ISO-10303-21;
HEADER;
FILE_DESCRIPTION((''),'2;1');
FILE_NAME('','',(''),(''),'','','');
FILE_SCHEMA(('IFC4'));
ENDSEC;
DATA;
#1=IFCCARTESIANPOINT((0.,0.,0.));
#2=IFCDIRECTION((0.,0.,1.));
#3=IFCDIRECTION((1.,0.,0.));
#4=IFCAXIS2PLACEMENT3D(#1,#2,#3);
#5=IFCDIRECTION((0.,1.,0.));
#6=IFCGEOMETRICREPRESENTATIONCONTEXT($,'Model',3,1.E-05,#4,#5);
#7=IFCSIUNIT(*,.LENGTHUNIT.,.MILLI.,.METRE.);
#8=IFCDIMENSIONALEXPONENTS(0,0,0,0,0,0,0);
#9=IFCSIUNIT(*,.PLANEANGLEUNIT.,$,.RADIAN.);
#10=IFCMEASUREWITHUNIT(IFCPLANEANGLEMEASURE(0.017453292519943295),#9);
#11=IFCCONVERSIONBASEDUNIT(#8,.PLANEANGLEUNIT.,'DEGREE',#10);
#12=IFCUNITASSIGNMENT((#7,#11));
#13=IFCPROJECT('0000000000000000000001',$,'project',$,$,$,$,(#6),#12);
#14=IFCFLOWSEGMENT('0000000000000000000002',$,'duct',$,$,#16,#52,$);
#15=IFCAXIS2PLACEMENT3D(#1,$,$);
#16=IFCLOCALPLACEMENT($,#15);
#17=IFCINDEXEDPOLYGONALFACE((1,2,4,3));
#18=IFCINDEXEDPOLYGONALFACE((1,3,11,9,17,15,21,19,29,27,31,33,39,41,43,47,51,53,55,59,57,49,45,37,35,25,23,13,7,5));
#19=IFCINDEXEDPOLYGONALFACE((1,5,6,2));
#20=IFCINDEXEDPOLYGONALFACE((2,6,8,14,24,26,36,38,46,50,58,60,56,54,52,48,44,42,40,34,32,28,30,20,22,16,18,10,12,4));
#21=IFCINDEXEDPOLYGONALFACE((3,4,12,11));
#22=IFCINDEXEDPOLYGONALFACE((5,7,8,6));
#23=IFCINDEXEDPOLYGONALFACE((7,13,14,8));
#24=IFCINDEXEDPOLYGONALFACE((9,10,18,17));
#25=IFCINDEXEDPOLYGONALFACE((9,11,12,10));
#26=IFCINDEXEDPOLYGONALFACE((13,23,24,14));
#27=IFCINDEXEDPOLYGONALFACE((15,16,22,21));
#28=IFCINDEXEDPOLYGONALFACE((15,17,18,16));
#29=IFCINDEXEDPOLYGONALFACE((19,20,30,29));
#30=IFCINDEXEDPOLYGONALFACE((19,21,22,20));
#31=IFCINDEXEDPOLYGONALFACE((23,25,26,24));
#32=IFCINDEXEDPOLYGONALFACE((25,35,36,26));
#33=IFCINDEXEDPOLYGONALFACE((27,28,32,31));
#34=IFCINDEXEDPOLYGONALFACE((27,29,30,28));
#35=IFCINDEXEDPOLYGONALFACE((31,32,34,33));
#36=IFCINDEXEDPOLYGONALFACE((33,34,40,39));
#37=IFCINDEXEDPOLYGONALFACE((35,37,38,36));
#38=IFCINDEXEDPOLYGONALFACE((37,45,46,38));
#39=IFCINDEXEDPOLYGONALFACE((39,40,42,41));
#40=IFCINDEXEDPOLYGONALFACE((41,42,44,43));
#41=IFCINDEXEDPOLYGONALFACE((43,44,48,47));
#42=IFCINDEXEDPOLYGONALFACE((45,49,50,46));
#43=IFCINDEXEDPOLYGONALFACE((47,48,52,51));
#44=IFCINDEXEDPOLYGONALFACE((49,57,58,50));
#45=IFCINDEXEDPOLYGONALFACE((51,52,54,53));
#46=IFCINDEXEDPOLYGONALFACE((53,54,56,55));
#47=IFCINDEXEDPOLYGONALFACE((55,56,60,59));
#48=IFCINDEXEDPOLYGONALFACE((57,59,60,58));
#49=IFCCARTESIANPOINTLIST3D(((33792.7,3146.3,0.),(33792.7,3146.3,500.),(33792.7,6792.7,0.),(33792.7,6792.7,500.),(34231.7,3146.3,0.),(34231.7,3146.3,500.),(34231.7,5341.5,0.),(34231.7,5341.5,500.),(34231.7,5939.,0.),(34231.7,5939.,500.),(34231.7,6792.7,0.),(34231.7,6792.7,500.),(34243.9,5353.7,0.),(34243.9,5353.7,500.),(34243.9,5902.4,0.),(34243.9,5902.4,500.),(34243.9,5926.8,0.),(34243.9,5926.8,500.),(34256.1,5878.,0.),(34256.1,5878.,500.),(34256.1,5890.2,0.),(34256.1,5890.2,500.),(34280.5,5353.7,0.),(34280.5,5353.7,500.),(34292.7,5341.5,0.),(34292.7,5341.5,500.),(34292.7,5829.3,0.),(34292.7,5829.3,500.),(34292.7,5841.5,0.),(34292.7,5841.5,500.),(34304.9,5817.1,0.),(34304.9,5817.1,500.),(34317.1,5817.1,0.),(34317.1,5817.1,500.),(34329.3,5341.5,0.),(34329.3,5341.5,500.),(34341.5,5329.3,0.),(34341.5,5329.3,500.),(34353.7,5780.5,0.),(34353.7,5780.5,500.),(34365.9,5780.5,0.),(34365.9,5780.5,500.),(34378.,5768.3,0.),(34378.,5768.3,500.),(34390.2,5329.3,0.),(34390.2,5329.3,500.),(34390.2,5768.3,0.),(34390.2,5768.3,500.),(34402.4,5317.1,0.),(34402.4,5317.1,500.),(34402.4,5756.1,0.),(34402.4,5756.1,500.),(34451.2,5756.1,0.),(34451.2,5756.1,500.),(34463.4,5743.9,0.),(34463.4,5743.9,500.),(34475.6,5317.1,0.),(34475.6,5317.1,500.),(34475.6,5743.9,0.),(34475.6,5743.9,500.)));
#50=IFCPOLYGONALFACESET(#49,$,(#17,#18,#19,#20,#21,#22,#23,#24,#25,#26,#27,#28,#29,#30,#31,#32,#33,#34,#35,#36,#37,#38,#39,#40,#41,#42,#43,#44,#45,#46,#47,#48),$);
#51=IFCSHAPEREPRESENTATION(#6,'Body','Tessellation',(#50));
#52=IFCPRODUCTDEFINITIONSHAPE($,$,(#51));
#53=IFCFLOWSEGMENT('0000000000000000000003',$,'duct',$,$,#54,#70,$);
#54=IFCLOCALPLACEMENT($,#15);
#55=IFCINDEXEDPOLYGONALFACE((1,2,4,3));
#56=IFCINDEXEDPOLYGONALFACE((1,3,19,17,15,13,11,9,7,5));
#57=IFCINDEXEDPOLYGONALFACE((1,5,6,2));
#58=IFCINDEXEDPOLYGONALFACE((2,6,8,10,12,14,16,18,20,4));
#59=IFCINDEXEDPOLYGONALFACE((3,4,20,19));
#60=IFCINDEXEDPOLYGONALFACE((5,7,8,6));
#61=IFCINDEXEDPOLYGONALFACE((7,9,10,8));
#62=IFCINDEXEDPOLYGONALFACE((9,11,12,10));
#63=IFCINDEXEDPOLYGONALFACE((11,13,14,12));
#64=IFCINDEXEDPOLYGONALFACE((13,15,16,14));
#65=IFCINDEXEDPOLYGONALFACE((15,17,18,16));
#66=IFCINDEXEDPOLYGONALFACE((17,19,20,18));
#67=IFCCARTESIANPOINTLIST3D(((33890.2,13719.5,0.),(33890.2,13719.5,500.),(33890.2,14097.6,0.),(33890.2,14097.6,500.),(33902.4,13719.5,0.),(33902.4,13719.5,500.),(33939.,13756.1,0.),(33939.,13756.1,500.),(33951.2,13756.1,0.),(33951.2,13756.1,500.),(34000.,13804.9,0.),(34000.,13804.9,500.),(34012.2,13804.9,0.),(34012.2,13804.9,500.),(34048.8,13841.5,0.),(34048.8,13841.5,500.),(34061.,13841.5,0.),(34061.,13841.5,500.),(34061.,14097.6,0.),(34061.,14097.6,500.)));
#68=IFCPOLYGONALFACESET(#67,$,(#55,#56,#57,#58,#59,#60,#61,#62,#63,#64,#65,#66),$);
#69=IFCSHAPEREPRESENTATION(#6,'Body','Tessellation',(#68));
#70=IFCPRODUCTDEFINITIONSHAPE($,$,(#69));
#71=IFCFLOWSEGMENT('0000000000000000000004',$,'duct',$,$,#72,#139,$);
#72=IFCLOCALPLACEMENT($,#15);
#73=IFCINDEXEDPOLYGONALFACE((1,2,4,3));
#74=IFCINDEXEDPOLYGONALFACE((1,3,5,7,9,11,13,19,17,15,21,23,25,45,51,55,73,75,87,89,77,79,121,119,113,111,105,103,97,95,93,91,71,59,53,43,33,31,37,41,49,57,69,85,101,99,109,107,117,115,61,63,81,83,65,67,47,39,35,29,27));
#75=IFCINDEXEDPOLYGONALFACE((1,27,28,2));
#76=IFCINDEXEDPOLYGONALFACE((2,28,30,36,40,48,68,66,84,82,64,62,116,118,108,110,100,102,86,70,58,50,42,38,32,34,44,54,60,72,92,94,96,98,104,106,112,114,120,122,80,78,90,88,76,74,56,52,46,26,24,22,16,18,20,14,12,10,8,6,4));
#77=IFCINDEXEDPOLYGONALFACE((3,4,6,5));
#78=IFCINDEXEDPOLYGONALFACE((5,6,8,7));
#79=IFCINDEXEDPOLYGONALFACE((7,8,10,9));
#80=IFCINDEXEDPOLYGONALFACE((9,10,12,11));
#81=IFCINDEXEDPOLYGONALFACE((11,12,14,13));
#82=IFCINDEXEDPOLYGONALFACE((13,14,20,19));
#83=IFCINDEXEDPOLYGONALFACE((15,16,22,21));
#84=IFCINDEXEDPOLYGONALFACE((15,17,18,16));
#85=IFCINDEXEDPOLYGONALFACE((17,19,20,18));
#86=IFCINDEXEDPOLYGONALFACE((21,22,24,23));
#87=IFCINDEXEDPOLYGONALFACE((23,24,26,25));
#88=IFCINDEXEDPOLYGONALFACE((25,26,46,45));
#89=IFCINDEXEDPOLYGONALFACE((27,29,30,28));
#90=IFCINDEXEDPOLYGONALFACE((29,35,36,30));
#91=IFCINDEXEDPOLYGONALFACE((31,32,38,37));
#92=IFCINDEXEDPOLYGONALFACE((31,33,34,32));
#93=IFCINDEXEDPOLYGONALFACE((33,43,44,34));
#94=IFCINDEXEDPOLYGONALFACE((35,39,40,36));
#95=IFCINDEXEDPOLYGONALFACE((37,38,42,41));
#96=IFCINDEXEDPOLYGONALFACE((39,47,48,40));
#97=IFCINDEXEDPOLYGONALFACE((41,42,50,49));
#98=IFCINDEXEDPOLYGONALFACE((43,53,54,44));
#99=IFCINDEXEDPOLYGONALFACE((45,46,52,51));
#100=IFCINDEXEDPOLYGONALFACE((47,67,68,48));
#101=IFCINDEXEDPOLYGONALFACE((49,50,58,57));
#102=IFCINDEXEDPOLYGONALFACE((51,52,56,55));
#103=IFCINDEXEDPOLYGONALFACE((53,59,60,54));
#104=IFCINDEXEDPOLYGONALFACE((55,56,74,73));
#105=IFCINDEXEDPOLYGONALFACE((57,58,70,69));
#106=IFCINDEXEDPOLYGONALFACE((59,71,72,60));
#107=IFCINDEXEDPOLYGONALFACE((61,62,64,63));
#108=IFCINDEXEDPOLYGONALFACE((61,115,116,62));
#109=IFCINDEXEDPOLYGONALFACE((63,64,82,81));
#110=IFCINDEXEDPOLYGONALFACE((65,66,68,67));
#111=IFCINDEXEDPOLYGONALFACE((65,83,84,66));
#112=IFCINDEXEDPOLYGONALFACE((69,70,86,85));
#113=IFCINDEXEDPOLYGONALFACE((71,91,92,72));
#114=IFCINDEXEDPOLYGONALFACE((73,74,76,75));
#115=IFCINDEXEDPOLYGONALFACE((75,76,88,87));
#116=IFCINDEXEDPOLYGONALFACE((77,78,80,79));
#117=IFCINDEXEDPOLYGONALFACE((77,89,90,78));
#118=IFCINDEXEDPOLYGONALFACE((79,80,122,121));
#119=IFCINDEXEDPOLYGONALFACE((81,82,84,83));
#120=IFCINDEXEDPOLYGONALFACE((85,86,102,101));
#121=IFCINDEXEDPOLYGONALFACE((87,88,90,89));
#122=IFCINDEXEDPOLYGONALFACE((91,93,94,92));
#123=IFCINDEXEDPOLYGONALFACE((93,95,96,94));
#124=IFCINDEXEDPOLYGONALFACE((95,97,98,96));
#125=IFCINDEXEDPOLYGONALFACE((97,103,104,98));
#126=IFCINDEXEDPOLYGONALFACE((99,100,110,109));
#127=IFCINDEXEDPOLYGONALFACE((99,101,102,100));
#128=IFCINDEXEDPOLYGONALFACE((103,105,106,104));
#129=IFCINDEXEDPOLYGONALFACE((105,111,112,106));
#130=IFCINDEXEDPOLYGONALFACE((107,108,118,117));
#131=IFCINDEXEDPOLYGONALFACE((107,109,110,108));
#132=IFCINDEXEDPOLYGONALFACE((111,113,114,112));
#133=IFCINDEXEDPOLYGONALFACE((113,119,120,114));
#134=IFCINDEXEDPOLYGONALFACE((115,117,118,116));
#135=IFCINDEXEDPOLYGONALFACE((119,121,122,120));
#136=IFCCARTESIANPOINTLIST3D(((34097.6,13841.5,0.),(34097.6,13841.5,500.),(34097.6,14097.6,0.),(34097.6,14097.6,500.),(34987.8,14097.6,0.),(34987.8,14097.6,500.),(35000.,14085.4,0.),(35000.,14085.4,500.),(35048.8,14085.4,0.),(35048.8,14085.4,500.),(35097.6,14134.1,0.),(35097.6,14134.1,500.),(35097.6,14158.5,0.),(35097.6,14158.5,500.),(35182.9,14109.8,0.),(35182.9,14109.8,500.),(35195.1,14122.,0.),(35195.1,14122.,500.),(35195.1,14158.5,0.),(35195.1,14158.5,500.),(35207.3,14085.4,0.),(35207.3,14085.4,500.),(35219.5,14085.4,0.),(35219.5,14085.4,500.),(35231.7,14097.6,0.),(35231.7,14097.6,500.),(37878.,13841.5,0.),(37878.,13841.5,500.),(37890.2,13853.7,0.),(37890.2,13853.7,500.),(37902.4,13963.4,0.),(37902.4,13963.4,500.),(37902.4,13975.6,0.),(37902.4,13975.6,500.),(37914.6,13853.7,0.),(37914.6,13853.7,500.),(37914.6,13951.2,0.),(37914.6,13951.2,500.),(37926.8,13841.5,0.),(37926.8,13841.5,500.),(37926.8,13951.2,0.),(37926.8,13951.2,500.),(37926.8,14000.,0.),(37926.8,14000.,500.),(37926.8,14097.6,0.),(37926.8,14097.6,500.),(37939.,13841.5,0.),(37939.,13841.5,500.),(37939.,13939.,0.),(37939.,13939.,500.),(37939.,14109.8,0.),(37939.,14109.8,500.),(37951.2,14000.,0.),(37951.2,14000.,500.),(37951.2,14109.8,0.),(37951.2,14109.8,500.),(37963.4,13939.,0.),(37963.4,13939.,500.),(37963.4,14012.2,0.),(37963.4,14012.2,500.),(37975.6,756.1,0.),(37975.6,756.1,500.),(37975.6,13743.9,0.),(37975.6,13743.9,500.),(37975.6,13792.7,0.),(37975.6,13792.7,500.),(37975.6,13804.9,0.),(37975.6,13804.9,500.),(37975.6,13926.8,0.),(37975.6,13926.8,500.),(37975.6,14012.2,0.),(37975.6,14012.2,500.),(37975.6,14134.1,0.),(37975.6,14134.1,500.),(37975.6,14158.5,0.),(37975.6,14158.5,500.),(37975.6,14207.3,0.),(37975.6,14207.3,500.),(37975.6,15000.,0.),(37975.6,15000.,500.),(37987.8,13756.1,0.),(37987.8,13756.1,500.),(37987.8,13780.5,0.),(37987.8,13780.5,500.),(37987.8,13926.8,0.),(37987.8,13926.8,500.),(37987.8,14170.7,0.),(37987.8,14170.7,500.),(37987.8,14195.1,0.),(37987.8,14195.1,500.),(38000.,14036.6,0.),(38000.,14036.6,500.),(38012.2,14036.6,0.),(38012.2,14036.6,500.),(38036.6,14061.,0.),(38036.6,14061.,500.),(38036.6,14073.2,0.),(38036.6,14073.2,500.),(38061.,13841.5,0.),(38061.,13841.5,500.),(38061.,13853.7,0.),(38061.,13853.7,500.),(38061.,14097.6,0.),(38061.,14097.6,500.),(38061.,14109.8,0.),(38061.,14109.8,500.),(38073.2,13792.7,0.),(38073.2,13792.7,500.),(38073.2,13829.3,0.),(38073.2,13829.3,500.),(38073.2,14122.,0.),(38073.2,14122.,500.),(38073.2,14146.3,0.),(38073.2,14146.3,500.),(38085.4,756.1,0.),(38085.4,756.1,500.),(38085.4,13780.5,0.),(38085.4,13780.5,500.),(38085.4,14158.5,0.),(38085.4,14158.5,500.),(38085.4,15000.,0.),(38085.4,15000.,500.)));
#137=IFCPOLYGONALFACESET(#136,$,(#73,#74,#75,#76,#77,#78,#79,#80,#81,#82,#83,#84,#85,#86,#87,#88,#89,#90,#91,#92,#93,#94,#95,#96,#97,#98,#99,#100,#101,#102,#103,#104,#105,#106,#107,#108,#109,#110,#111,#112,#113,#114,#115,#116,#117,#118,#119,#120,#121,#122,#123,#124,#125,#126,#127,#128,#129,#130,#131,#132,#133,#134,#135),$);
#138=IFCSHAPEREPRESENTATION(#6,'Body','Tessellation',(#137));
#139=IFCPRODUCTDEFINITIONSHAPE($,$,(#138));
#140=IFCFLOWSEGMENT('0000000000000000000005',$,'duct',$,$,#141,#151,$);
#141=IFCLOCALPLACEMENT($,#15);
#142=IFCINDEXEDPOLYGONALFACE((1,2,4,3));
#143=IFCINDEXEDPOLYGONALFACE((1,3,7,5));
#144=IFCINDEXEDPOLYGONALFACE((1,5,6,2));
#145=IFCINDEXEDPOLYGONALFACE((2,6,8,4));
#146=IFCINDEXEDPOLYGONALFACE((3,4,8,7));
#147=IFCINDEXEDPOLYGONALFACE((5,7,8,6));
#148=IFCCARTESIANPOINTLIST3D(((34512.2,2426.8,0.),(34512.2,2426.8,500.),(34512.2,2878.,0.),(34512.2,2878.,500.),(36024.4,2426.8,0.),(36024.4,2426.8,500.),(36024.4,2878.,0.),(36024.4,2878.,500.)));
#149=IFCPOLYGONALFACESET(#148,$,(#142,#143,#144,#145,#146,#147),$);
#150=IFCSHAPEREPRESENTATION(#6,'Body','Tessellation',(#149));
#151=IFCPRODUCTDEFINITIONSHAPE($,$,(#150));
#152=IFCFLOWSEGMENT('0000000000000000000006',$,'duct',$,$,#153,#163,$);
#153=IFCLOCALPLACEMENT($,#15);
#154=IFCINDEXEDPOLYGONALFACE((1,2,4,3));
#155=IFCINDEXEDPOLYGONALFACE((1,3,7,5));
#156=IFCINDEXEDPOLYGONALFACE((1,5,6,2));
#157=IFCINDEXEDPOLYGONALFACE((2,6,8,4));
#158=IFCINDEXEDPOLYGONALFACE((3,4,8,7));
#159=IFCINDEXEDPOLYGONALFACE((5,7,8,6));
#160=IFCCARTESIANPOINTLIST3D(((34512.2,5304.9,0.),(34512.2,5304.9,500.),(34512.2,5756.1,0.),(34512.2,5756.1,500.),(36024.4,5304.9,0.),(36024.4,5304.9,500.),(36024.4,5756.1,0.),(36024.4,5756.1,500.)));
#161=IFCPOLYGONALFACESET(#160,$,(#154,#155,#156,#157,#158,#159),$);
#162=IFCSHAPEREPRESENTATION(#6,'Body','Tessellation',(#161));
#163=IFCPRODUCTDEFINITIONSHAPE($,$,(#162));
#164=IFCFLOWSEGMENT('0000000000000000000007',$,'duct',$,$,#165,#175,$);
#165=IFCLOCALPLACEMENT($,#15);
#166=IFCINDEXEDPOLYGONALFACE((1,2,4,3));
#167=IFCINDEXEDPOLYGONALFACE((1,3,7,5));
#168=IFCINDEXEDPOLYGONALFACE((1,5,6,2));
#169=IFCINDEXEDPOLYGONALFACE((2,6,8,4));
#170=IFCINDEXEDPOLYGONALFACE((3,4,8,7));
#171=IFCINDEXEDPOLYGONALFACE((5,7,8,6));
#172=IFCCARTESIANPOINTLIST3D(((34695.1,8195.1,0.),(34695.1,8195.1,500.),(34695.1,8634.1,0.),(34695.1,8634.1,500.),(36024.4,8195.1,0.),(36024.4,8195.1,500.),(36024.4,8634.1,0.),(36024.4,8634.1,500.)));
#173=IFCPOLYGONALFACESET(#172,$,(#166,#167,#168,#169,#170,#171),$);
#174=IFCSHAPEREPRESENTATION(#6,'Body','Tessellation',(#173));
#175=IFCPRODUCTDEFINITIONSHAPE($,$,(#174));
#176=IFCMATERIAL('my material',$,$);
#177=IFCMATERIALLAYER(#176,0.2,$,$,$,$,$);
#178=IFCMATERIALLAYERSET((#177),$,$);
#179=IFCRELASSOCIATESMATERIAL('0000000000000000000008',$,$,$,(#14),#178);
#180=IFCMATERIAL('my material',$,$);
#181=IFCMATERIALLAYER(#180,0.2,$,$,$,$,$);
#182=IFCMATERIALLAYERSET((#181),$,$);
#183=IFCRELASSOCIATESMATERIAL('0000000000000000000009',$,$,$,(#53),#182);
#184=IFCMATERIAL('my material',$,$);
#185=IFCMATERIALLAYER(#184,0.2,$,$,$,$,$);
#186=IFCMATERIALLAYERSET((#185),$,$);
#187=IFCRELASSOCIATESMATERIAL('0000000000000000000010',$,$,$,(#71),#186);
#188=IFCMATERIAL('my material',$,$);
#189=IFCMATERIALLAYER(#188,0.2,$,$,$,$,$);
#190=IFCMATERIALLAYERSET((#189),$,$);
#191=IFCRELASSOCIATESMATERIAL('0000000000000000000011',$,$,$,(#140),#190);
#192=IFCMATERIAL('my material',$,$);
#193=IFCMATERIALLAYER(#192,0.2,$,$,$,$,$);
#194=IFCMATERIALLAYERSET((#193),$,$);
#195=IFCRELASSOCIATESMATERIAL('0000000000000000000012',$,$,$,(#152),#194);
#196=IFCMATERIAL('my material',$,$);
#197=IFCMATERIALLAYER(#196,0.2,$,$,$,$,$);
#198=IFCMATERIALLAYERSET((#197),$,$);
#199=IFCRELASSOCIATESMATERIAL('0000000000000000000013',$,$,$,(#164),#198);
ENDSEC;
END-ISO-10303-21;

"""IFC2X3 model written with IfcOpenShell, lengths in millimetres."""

from ifc_helpers import new_model, entity, si_unit, converted_unit, direction, origin_with_axes, place, context, project, polyline, outline, extrude, material, layer, layer_set, layer_usage, element, save


model = new_model("IFC2X3")

# Units and contexts
model_context = context("Model", 3, precision=1e-05, world=origin_with_axes(), true_north=direction((0.0, 1.0, 0.0)))
ifc_project = project(units=[si_unit("LENGTHUNIT", "METRE", prefix="MILLI"), converted_unit("PLANEANGLEUNIT", "DEGREE", entity("IfcPlaneAngleMeasure", 0.017453292519943295), si_unit("PLANEANGLEUNIT", "RADIAN"), dimensions=[0, 0, 0, 0, 0, 0, 0])], contexts=[model_context])

# Flow segments
ifc_material_1 = material(Name="my material")
ifc_layer_1 = layer(ifc_material_1, 0.2)
ifc_layer_set_1 = layer_set([ifc_layer_1])
ifc_layer_usage_1 = layer_usage(ifc_layer_set_1, "AXIS2", "POSITIVE", -0.1)
flow_segment_1_placement = place(None, origin_with_axes())
element("IfcFlowSegment", 1, at=flow_segment_1_placement, material=ifc_layer_usage_1, Name="duct", context=model_context, shape_type="SweptSolid", body=[
    extrude(outline(polyline([(33792.7, 3146.3), (34231.7, 3146.3), (34231.7, 5341.5), (34243.9, 5353.7), (34280.5, 5353.7), (34292.7, 5341.5), (34329.3, 5341.5), (34341.5, 5329.3), (34390.2, 5329.3), (34402.4, 5317.1), (34475.6, 5317.1), (34475.6, 5743.9), (34463.4, 5743.9), (34451.2, 5756.1), (34402.4, 5756.1), (34390.2, 5768.3), (34378.0, 5768.3), (34365.9, 5780.5), (34353.7, 5780.5), (34317.1, 5817.1), (34304.9, 5817.1), (34292.7, 5829.3), (34292.7, 5841.5), (34256.1, 5878.0), (34256.1, 5890.2), (34243.9, 5902.4), (34243.9, 5926.8), (34231.7, 5939.0), (34231.7, 6792.7), (33792.7, 6792.7), (33792.7, 3146.3)])), origin_with_axes(), (0.0, 0.0, 1.0), 500.0),
])
ifc_material_2 = material(Name="my material")
ifc_layer_2 = layer(ifc_material_2, 0.2)
ifc_layer_set_2 = layer_set([ifc_layer_2])
ifc_layer_usage_2 = layer_usage(ifc_layer_set_2, "AXIS2", "POSITIVE", -0.1)
flow_segment_2_placement = place(None, origin_with_axes())
element("IfcFlowSegment", 2, at=flow_segment_2_placement, material=ifc_layer_usage_2, Name="duct", context=model_context, shape_type="SweptSolid", body=[
    extrude(outline(polyline([(33890.2, 13719.5), (33902.4, 13719.5), (33939.0, 13756.1), (33951.2, 13756.1), (34000.0, 13804.9), (34012.2, 13804.9), (34048.8, 13841.5), (34061.0, 13841.5), (34061.0, 14097.6), (33890.2, 14097.6), (33890.2, 13719.5)])), origin_with_axes(), (0.0, 0.0, 1.0), 500.0),
])
ifc_material_3 = material(Name="my material")
ifc_layer_3 = layer(ifc_material_3, 0.2)
ifc_layer_set_3 = layer_set([ifc_layer_3])
ifc_layer_usage_3 = layer_usage(ifc_layer_set_3, "AXIS2", "POSITIVE", -0.1)
flow_segment_3_placement = place(None, origin_with_axes())
element("IfcFlowSegment", 3, at=flow_segment_3_placement, material=ifc_layer_usage_3, Name="duct", context=model_context, shape_type="SweptSolid", body=[
    extrude(outline(polyline([(34097.6, 13841.5), (37878.0, 13841.5), (37890.2, 13853.7), (37914.6, 13853.7), (37926.8, 13841.5), (37939.0, 13841.5), (37975.6, 13804.9), (37975.6, 13792.7), (37987.8, 13780.5), (37987.8, 13756.1), (37975.6, 13743.9), (37975.6, 756.1), (38085.4, 756.1), (38085.4, 13780.5), (38073.2, 13792.7), (38073.2, 13829.3), (38061.0, 13841.5), (38061.0, 13853.7), (37987.8, 13926.8), (37975.6, 13926.8), (37963.4, 13939.0), (37939.0, 13939.0), (37926.8, 13951.2), (37914.6, 13951.2), (37902.4, 13963.4), (37902.4, 13975.6), (37926.8, 14000.0), (37951.2, 14000.0), (37963.4, 14012.2), (37975.6, 14012.2), (38000.0, 14036.6), (38012.2, 14036.6), (38036.6, 14061.0), (38036.6, 14073.2), (38061.0, 14097.6), (38061.0, 14109.8), (38073.2, 14122.0), (38073.2, 14146.3), (38085.4, 14158.5), (38085.4, 15000.0), (37975.6, 15000.0), (37975.6, 14207.3), (37987.8, 14195.1), (37987.8, 14170.7), (37975.6, 14158.5), (37975.6, 14134.1), (37951.2, 14109.8), (37939.0, 14109.8), (37926.8, 14097.6), (35231.7, 14097.6), (35219.5, 14085.4), (35207.3, 14085.4), (35182.9, 14109.8), (35195.1, 14122.0), (35195.1, 14158.5), (35097.6, 14158.5), (35097.6, 14134.1), (35048.8, 14085.4), (35000.0, 14085.4), (34987.8, 14097.6), (34097.6, 14097.6), (34097.6, 13841.5)])), origin_with_axes(), (0.0, 0.0, 1.0), 500.0),
])
ifc_material_4 = material(Name="my material")
ifc_layer_4 = layer(ifc_material_4, 0.2)
ifc_layer_set_4 = layer_set([ifc_layer_4])
ifc_layer_usage_4 = layer_usage(ifc_layer_set_4, "AXIS2", "POSITIVE", -0.1)
flow_segment_4_placement = place(None, origin_with_axes())
element("IfcFlowSegment", 4, at=flow_segment_4_placement, material=ifc_layer_usage_4, Name="duct", context=model_context, shape_type="SweptSolid", body=[
    extrude(outline(polyline([(34512.2, 2426.8), (36024.4, 2426.8), (36024.4, 2878.0), (34512.2, 2878.0), (34512.2, 2426.8)])), origin_with_axes(), (0.0, 0.0, 1.0), 500.0),
])
ifc_material_5 = material(Name="my material")
ifc_layer_5 = layer(ifc_material_5, 0.2)
ifc_layer_set_5 = layer_set([ifc_layer_5])
ifc_layer_usage_5 = layer_usage(ifc_layer_set_5, "AXIS2", "POSITIVE", -0.1)
flow_segment_5_placement = place(None, origin_with_axes())
element("IfcFlowSegment", 5, at=flow_segment_5_placement, material=ifc_layer_usage_5, Name="duct", context=model_context, shape_type="SweptSolid", body=[
    extrude(outline(polyline([(34512.2, 5304.9), (36024.4, 5304.9), (36024.4, 5756.1), (34512.2, 5756.1), (34512.2, 5304.9)])), origin_with_axes(), (0.0, 0.0, 1.0), 500.0),
])
ifc_material_6 = material(Name="my material")
ifc_layer_6 = layer(ifc_material_6, 0.2)
ifc_layer_set_6 = layer_set([ifc_layer_6])
ifc_layer_usage_6 = layer_usage(ifc_layer_set_6, "AXIS2", "POSITIVE", -0.1)
flow_segment_6_placement = place(None, origin_with_axes())
element("IfcFlowSegment", 6, at=flow_segment_6_placement, material=ifc_layer_usage_6, Name="duct", context=model_context, shape_type="SweptSolid", body=[
    extrude(outline(polyline([(34695.1, 8195.1), (36024.4, 8195.1), (36024.4, 8634.1), (34695.1, 8634.1), (34695.1, 8195.1)])), origin_with_axes(), (0.0, 0.0, 1.0), 500.0),
])

save(model, "model.ifc")
